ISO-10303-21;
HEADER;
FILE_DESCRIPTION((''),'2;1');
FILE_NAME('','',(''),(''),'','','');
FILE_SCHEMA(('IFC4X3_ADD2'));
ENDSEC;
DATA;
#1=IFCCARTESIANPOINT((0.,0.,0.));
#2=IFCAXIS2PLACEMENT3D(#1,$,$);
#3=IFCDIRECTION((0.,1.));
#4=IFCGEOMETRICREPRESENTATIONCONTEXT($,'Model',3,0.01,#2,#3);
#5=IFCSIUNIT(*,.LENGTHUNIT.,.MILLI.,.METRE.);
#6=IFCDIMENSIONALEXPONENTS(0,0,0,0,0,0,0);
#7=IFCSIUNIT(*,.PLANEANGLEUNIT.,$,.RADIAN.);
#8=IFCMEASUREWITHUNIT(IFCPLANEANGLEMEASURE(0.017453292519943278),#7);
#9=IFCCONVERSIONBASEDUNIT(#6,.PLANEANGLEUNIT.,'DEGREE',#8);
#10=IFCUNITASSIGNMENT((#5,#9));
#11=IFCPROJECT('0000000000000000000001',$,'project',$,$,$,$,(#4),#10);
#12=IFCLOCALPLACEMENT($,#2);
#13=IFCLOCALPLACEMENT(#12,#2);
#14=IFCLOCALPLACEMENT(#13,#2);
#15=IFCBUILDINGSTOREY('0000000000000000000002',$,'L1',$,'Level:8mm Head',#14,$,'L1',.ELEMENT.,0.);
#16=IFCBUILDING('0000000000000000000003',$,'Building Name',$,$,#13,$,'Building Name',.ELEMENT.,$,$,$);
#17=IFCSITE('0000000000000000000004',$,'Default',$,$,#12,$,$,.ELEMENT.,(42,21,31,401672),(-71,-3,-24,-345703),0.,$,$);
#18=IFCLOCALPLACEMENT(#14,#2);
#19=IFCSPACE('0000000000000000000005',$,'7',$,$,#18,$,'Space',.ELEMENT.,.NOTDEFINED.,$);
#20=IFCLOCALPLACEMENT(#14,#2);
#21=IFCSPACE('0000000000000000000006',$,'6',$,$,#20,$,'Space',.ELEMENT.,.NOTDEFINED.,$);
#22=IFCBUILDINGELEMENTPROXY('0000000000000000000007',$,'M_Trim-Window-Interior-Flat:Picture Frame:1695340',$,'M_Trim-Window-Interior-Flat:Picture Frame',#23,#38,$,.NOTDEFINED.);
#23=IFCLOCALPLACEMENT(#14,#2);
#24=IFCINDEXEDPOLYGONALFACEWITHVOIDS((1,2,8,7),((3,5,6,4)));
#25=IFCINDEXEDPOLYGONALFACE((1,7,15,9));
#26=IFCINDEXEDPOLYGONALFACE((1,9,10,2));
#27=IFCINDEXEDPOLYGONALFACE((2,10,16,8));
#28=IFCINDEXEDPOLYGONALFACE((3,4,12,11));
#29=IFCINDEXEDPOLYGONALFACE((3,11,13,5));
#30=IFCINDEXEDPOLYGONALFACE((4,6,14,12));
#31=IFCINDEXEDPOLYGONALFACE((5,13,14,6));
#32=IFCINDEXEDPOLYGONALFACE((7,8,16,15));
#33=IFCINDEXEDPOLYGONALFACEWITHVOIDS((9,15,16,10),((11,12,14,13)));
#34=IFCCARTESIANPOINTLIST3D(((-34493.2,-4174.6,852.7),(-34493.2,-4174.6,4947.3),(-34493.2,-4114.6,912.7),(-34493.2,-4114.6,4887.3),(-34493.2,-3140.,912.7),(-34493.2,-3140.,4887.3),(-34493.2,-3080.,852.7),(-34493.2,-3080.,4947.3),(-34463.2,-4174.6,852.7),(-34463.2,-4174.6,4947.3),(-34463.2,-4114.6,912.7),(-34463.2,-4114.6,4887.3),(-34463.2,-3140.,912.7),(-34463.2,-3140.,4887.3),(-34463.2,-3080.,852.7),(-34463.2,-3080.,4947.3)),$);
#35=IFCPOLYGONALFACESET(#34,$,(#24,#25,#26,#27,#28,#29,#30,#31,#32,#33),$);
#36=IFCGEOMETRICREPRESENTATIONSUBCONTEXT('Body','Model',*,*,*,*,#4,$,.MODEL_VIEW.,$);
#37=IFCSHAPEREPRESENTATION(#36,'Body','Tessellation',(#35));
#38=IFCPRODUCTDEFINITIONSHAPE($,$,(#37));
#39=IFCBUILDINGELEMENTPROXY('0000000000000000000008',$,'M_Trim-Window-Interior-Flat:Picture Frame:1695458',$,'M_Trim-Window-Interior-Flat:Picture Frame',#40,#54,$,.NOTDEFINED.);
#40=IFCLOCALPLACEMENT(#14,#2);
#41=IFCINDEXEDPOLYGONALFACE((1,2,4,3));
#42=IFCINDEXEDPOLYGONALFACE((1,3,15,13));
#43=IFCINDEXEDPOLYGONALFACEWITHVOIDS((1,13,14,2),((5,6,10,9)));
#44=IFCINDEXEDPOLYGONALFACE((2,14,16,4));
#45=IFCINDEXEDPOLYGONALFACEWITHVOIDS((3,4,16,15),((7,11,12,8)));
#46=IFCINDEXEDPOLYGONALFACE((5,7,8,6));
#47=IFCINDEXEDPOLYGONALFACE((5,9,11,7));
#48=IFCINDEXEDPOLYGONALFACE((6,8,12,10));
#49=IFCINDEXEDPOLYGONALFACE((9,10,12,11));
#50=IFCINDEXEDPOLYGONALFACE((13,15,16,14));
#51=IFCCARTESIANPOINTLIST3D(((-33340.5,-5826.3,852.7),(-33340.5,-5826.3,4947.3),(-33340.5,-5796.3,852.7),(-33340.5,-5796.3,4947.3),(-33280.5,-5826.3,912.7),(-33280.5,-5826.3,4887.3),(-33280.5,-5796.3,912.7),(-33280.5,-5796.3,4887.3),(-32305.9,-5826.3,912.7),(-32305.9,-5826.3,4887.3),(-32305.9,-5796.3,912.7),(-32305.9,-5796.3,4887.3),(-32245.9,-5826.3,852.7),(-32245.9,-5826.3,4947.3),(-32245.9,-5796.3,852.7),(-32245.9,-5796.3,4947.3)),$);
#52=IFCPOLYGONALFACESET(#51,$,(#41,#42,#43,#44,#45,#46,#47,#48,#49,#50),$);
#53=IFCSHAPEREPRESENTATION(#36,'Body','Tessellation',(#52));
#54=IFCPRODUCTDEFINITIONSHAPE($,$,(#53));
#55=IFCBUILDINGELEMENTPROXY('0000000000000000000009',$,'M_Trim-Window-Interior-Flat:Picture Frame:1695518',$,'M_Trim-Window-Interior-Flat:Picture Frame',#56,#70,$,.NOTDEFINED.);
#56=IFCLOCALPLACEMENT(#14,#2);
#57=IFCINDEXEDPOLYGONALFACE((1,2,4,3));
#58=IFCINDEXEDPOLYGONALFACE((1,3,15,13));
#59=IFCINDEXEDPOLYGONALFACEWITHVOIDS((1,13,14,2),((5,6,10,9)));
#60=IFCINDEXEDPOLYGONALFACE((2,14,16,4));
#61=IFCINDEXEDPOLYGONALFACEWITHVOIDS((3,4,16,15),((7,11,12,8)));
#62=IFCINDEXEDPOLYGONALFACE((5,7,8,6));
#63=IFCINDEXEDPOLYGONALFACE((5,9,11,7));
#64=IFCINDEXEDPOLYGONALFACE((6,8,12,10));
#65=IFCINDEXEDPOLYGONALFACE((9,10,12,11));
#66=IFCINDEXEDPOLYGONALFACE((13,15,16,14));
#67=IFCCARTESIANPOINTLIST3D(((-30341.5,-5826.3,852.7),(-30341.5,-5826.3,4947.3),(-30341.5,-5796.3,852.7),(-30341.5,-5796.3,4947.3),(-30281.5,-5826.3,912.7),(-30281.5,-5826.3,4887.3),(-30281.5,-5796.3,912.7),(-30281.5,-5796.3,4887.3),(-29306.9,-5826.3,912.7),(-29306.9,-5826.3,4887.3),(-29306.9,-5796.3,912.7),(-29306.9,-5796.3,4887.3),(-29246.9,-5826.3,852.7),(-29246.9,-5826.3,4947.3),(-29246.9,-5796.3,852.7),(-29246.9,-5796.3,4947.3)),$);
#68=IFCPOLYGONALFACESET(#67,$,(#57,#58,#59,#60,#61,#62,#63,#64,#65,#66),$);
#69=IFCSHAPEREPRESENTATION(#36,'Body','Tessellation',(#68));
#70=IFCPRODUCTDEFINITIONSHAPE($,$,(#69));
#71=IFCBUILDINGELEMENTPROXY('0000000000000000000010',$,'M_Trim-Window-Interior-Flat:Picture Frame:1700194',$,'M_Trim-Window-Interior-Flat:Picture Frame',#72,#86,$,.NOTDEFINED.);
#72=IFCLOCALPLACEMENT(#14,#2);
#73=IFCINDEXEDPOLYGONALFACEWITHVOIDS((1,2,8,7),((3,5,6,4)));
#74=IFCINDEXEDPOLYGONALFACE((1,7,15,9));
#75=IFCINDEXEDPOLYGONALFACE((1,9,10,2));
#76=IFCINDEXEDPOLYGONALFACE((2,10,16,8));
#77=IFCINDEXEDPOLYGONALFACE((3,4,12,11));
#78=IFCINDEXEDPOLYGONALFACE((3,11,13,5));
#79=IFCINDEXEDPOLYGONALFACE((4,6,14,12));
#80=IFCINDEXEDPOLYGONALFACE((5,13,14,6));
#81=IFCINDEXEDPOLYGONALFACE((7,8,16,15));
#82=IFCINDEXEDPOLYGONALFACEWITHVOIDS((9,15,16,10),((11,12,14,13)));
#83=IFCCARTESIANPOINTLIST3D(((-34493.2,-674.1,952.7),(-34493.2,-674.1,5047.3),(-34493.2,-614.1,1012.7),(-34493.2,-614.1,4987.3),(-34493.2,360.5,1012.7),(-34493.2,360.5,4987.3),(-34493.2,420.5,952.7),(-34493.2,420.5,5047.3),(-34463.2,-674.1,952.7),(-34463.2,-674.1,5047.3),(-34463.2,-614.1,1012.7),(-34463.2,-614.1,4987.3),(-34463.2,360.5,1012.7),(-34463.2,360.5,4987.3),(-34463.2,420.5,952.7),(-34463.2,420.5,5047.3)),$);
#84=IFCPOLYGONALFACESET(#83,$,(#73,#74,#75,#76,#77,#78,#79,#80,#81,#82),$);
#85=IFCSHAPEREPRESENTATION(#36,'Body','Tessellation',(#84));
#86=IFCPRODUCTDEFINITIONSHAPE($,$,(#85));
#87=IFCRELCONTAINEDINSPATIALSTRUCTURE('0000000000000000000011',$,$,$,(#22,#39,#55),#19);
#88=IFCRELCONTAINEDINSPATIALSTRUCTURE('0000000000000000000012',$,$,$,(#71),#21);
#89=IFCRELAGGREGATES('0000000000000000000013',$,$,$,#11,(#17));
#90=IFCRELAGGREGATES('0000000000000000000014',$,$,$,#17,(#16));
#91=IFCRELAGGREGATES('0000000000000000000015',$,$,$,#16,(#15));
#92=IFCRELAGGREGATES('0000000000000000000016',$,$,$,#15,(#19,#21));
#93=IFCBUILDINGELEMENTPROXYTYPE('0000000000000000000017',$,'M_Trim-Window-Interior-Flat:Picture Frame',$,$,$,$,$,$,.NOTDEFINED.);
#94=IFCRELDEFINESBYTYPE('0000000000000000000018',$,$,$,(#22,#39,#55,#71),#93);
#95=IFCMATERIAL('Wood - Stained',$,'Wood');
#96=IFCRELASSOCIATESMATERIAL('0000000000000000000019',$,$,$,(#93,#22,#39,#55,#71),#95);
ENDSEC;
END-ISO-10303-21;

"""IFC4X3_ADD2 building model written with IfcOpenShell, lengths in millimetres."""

from ifc_helpers import new_model, entity, si_unit, converted_unit, direction, frame, origin, place, context, subcontext, project, spatial, polyline, outline, extrude, source, transform, mapped, material, type_object, type_shapes, element, save


model = new_model("IFC4X3_ADD2")

# Units and contexts
model_context = context("Model", 3, precision=0.01, world=origin(), true_north=direction((0.0, 1.0)))
body_context = subcontext(model_context, "Body", "Model", "MODEL_VIEW")
ifc_project = project(units=[si_unit("LENGTHUNIT", "METRE", prefix="MILLI"), converted_unit("PLANEANGLEUNIT", "DEGREE", entity("IfcPlaneAngleMeasure", 0.017453292519943278), si_unit("PLANEANGLEUNIT", "RADIAN"), dimensions=[0, 0, 0, 0, 0, 0, 0])], contexts=[model_context])

# Site, building, storey
site_placement = place(None, origin())
site = spatial("IfcSite", under=ifc_project, at=site_placement, Name="Default", CompositionType="ELEMENT", RefLatitude=(42, 21, 31, 401672), RefLongitude=(-71, -3, -24, -345703), RefElevation=0.0)
building_placement = place(site_placement, origin())
building = spatial("IfcBuilding", under=site, at=building_placement, Name="Building Name", LongName="Building Name", CompositionType="ELEMENT")
storey_placement = place(building_placement, origin())
storey = spatial("IfcBuildingStorey", under=building, at=storey_placement, Name="L1", ObjectType="Level:8mm Head", LongName="L1", CompositionType="ELEMENT", Elevation=0.0)

# Shared definitions
ifc_material_1 = material(Name="Wood - Stained", Category="Wood")

# Shared definitions
building_element_proxy_type_1 = type_object("IfcBuildingElementProxyType", Name="M_Trim-Window-Interior-Flat:Picture Frame", PredefinedType="NOTDEFINED", material=ifc_material_1)
shared_shape_1 = source(origin(), body_context, "Body", "SweptSolid", [
    extrude(outline(polyline([(-547.3, -2047.3), (547.3, -2047.3), (547.3, 2047.3), (-547.3, 2047.3), (-547.3, -2047.3)]), holes=[polyline([(-487.3, -1987.3), (-487.3, 1987.3), (487.3, 1987.3), (487.3, -1987.3), (-487.3, -1987.3)])]), frame((0.0, -2000.0, 0.0), z_axis=(0.0, 0.0, 1.0), x_axis=(-1.0, 0.0, 0.0)), (0.0, 0.0, 1.0), 30.0),
])
type_shapes(building_element_proxy_type_1, [shared_shape_1])

# Shared definitions
space_1_placement = place(storey_placement, origin())
space_1 = spatial("IfcSpace", under=storey, at=space_1_placement, Name="7", LongName="Space", CompositionType="ELEMENT", PredefinedType="NOTDEFINED")

# Building element proxies
for number, where, z_axis, x_axis, name in (
    (1, (-34493.2, -3627.3, 4900.0), (1.0, 0.0, 0.0), (0.0, 1.0, 0.0), "M_Trim-Window-Interior-Flat:Picture Frame:1695340"),
    (2, (-32793.2, -5826.3, 4900.0), (0.0, 1.0, 0.0), (-1.0, 0.0, 0.0), "M_Trim-Window-Interior-Flat:Picture Frame:1695458"),
    (3, (-29794.2, -5826.3, 4900.0), (0.0, 1.0, 0.0), (-1.0, 0.0, 0.0), "M_Trim-Window-Interior-Flat:Picture Frame:1695518"),
):
    element("IfcBuildingElementProxy", number, at=place(space_1_placement, frame(where, z_axis=z_axis, x_axis=x_axis)), inside=space_1, type_object=building_element_proxy_type_1, material=ifc_material_1, Name=name, ObjectType="M_Trim-Window-Interior-Flat:Picture Frame", PredefinedType="NOTDEFINED", context=body_context, shape_type="MappedRepresentation", body=[
        mapped(shared_shape_1, transform((0.0, 0.0, 0.0), scale=1.0)),
    ])

# Shared definitions
space_2_placement = place(storey_placement, origin())
space_2 = spatial("IfcSpace", under=storey, at=space_2_placement, Name="6", LongName="Space", CompositionType="ELEMENT", PredefinedType="NOTDEFINED")

# Building element proxy
proxy_1_placement = place(space_2_placement, frame((-34493.2, -126.8, 5000.0), z_axis=(1.0, 0.0, 0.0), x_axis=(0.0, 1.0, 0.0)))
element("IfcBuildingElementProxy", 4, at=proxy_1_placement, inside=space_2, type_object=building_element_proxy_type_1, material=ifc_material_1, Name="M_Trim-Window-Interior-Flat:Picture Frame:1700194", ObjectType="M_Trim-Window-Interior-Flat:Picture Frame", PredefinedType="NOTDEFINED", context=body_context, shape_type="MappedRepresentation", body=[
    mapped(shared_shape_1, transform((0.0, 0.0, 0.0), scale=1.0)),
])

save(model, "model.ifc")
